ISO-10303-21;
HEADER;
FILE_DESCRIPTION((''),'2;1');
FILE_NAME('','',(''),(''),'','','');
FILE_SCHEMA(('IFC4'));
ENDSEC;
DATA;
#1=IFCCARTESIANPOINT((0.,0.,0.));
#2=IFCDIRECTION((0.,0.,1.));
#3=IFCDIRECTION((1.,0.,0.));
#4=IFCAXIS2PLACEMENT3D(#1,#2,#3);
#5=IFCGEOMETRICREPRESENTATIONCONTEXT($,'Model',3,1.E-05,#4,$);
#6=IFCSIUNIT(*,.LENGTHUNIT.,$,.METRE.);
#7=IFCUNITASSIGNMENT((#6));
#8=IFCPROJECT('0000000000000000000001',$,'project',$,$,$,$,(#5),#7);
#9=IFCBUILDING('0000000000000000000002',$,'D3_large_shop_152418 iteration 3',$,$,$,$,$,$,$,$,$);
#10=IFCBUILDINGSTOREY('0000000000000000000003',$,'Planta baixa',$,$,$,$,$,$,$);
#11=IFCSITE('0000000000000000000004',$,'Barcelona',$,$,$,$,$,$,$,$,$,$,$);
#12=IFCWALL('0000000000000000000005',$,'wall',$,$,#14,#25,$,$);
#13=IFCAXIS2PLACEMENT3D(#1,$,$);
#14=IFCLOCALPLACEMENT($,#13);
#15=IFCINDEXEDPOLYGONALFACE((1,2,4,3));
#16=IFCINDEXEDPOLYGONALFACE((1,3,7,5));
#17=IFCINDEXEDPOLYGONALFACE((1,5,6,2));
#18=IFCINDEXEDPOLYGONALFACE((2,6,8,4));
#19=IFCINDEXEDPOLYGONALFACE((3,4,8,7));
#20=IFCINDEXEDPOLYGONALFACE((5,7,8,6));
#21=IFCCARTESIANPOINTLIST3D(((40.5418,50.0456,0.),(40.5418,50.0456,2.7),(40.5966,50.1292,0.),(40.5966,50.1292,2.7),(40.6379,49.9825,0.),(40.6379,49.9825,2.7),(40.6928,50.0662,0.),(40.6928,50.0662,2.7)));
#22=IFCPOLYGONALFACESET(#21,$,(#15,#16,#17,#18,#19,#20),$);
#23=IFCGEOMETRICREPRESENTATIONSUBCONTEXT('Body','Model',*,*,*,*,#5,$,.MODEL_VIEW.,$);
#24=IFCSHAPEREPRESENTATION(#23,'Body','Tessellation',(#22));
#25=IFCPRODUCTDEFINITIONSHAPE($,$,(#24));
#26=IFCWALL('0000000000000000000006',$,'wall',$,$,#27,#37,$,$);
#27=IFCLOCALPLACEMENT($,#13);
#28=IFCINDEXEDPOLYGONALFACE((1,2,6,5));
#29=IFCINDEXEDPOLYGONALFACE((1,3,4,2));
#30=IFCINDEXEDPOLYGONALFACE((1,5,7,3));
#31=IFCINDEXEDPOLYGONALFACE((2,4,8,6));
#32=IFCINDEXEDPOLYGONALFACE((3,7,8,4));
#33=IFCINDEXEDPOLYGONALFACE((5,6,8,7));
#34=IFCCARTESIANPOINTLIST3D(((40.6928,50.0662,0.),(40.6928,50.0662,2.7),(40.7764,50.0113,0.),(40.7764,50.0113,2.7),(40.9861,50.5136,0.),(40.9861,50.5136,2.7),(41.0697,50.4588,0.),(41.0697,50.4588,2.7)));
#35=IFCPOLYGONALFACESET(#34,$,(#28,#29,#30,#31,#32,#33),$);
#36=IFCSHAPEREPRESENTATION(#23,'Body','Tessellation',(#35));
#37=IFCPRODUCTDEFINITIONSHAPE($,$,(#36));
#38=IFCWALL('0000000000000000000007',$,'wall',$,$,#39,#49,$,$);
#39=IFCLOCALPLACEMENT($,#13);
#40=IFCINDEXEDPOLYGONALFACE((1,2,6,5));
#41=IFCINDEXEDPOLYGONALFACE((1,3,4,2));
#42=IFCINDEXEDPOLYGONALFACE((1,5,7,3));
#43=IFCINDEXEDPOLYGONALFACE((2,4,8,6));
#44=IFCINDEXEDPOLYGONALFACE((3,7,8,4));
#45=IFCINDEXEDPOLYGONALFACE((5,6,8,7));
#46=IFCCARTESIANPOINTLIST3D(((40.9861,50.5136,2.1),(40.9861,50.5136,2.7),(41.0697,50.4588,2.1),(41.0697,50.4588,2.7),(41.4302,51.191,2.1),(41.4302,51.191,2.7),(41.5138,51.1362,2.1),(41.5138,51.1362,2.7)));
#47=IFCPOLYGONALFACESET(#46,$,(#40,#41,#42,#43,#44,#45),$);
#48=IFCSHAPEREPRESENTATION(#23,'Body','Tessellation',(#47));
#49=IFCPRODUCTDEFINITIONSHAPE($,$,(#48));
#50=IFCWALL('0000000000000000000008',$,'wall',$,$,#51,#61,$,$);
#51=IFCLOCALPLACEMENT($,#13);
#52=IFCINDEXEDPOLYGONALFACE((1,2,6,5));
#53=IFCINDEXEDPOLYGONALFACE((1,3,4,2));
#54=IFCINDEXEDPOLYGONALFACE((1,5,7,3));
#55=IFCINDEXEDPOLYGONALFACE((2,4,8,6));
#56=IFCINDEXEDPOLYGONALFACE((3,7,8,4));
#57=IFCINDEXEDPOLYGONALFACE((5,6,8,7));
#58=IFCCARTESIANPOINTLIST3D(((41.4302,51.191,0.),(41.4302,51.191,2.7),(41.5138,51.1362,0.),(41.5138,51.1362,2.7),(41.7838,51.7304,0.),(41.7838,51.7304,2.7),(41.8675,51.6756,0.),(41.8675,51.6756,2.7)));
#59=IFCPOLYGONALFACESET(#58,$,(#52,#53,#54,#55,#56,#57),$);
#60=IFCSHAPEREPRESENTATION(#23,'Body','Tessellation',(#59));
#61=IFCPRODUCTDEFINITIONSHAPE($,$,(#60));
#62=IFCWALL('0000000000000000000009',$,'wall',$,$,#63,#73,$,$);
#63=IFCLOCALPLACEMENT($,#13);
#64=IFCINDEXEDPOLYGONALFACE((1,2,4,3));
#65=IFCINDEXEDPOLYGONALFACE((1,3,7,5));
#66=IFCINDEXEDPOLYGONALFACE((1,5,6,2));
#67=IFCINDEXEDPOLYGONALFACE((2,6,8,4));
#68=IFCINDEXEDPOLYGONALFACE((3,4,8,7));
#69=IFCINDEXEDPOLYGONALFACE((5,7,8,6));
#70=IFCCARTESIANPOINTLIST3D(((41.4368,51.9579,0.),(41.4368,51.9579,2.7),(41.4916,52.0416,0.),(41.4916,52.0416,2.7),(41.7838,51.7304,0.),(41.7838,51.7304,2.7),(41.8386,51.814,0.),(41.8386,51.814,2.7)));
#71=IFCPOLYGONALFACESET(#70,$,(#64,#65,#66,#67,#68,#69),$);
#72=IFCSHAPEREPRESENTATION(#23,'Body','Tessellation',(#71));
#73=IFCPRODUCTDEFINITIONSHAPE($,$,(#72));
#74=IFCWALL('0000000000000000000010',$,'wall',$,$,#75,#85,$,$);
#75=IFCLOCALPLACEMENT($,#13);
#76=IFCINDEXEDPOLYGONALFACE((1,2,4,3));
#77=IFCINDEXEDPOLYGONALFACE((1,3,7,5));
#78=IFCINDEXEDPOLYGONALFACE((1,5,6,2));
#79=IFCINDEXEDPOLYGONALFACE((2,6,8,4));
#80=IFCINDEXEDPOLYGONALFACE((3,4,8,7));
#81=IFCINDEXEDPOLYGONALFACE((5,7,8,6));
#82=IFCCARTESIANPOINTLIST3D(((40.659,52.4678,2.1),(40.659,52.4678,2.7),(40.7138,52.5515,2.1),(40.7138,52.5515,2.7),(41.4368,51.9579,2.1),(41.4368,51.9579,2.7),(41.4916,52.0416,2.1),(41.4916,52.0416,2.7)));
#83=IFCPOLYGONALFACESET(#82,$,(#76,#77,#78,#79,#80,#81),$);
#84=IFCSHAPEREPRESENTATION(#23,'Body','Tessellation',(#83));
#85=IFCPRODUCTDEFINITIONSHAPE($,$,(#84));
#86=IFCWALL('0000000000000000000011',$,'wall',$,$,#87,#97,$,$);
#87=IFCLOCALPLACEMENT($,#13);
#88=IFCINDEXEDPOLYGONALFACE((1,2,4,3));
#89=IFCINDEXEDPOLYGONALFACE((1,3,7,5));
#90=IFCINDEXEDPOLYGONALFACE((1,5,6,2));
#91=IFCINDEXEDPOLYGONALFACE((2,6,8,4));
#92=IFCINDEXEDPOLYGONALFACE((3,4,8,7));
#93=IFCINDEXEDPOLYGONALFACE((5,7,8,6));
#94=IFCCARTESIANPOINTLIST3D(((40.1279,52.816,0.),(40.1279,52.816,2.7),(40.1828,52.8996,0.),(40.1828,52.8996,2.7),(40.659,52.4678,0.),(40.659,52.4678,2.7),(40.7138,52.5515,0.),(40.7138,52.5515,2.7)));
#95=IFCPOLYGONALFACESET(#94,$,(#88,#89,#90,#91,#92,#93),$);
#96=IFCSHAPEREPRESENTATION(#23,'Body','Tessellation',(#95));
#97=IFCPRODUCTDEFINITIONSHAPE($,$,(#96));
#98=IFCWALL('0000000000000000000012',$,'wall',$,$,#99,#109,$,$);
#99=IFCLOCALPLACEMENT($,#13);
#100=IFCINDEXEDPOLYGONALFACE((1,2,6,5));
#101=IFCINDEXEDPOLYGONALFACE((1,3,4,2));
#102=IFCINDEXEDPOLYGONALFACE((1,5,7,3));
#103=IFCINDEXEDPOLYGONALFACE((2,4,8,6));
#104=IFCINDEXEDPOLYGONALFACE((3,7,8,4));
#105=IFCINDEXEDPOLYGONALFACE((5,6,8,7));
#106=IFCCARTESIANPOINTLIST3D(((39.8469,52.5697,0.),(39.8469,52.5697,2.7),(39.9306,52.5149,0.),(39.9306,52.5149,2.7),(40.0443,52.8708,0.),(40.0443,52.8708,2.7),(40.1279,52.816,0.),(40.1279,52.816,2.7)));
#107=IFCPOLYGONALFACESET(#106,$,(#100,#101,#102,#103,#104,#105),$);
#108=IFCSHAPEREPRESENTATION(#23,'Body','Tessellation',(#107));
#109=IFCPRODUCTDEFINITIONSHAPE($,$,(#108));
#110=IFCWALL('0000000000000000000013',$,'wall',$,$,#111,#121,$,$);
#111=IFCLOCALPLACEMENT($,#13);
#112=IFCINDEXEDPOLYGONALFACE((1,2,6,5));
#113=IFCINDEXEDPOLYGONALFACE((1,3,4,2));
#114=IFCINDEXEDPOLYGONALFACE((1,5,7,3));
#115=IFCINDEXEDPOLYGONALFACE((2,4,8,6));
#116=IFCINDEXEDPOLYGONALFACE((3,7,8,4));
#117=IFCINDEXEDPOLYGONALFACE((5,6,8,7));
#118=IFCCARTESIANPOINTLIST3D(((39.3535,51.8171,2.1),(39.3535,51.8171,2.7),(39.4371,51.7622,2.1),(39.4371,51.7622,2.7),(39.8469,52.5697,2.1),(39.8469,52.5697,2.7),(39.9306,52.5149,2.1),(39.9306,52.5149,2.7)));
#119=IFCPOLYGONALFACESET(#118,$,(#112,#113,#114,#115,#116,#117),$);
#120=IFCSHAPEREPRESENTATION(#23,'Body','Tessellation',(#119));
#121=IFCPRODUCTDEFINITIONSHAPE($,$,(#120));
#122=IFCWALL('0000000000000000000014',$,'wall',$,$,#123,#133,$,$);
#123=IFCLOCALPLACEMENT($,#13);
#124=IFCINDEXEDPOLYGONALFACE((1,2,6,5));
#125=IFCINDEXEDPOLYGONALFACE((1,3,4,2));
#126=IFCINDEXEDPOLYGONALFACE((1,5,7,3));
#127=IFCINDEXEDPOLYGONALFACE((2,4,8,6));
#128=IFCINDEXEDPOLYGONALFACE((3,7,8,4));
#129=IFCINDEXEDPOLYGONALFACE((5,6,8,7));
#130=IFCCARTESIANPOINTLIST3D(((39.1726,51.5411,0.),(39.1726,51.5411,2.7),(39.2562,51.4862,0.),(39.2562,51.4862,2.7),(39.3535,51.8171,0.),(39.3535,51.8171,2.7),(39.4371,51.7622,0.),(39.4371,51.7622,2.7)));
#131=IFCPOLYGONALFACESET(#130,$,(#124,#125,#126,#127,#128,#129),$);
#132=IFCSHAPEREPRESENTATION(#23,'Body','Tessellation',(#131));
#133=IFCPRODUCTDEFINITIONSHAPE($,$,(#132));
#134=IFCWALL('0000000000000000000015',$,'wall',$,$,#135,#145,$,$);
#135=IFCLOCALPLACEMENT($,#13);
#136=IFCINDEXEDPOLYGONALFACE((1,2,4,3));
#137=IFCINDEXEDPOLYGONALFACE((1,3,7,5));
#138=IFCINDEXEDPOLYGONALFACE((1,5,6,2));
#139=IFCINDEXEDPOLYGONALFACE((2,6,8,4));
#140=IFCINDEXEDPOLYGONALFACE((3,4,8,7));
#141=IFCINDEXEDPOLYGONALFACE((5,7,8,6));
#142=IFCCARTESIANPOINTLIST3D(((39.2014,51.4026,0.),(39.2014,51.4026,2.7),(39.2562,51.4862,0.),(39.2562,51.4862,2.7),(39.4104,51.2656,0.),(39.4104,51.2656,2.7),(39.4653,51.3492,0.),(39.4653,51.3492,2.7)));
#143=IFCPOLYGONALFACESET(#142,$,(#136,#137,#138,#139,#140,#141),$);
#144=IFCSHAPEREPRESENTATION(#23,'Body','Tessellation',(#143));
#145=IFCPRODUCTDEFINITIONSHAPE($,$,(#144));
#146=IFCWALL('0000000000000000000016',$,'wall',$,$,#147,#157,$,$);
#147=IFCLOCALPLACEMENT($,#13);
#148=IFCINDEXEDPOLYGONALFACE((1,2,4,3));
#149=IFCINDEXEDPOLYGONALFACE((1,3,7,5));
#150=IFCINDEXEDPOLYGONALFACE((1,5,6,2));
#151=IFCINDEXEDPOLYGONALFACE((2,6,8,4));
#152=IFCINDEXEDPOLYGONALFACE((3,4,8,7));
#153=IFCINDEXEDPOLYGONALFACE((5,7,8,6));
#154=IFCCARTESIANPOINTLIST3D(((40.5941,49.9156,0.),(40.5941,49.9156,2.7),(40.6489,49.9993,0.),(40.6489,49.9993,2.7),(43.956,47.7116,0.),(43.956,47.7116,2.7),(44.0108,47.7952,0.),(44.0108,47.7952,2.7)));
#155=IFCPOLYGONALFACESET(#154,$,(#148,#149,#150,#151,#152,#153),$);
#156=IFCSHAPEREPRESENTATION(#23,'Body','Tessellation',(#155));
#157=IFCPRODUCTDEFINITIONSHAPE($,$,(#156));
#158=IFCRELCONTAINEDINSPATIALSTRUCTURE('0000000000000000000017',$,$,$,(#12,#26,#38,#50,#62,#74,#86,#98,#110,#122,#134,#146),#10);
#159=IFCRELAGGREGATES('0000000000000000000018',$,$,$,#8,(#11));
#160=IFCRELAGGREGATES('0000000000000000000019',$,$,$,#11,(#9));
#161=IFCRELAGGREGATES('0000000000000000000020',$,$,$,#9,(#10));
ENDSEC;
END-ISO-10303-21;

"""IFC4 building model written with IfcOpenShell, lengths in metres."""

from ifc_helpers import new_model, si_unit, frame, origin, origin_with_axes, place, context, subcontext, project, spatial, polyline, outline, extrude, element, save


model = new_model("IFC4")

# Units and contexts
model_context = context("Model", 3, precision=1e-05, world=origin_with_axes())
body_context = subcontext(model_context, "Body", "Model", "MODEL_VIEW")
ifc_project = project(units=[si_unit("LENGTHUNIT", "METRE")], contexts=[model_context])

# Site, building, storey
site = spatial("IfcSite", under=ifc_project, Name="Barcelona")
building = spatial("IfcBuilding", under=site, Name="D3_large_shop_152418 iteration 3")
storey = spatial("IfcBuildingStorey", under=building, Name="Planta baixa")

# Walls
wall_1_placement = place(None, origin_with_axes())
element("IfcWall", 1, at=wall_1_placement, inside=storey, Name="wall", context=body_context, shape_type="SweptSolid", body=[
    extrude(outline(polyline([(40.5966, 50.1292), (40.6928, 50.0662), (40.6379, 49.9825), (40.5418, 50.0456), (40.5966, 50.1292)])), origin(), (0.0, 0.0, 1.0), 2.7),
])
wall_2_placement = place(None, origin_with_axes())
element("IfcWall", 2, at=wall_2_placement, inside=storey, Name="wall", context=body_context, shape_type="SweptSolid", body=[
    extrude(outline(polyline([(40.6928, 50.0662), (40.9861, 50.5136), (41.0697, 50.4588), (40.7764, 50.0113), (40.6928, 50.0662)])), origin(), (0.0, 0.0, 1.0), 2.7),
])
wall_3_placement = place(None, origin_with_axes())
element("IfcWall", 3, at=wall_3_placement, inside=storey, Name="wall", context=body_context, shape_type="SweptSolid", body=[
    extrude(outline(polyline([(40.9861, 50.5136), (41.4302, 51.191), (41.5138, 51.1362), (41.0697, 50.4588), (40.9861, 50.5136)])), frame((0.0, 0.0, 2.1)), (0.0, 0.0, 1.0), 0.6),
])
wall_4_placement = place(None, origin_with_axes())
element("IfcWall", 4, at=wall_4_placement, inside=storey, Name="wall", context=body_context, shape_type="SweptSolid", body=[
    extrude(outline(polyline([(41.4302, 51.191), (41.7838, 51.7304), (41.8675, 51.6756), (41.5138, 51.1362), (41.4302, 51.191)])), origin(), (0.0, 0.0, 1.0), 2.7),
])
wall_5_placement = place(None, origin_with_axes())
element("IfcWall", 5, at=wall_5_placement, inside=storey, Name="wall", context=body_context, shape_type="SweptSolid", body=[
    extrude(outline(polyline([(41.7838, 51.7304), (41.4368, 51.9579), (41.4916, 52.0416), (41.8386, 51.814), (41.7838, 51.7304)])), origin(), (0.0, 0.0, 1.0), 2.7),
])
wall_6_placement = place(None, origin_with_axes())
element("IfcWall", 6, at=wall_6_placement, inside=storey, Name="wall", context=body_context, shape_type="SweptSolid", body=[
    extrude(outline(polyline([(41.4368, 51.9579), (40.659, 52.4678), (40.7138, 52.5515), (41.4916, 52.0416), (41.4368, 51.9579)])), frame((0.0, 0.0, 2.1)), (0.0, 0.0, 1.0), 0.6),
])
wall_7_placement = place(None, origin_with_axes())
element("IfcWall", 7, at=wall_7_placement, inside=storey, Name="wall", context=body_context, shape_type="SweptSolid", body=[
    extrude(outline(polyline([(40.659, 52.4678), (40.1279, 52.816), (40.1828, 52.8996), (40.7138, 52.5515), (40.659, 52.4678)])), origin(), (0.0, 0.0, 1.0), 2.7),
])
wall_8_placement = place(None, origin_with_axes())
element("IfcWall", 8, at=wall_8_placement, inside=storey, Name="wall", context=body_context, shape_type="SweptSolid", body=[
    extrude(outline(polyline([(40.1279, 52.816), (39.9306, 52.5149), (39.8469, 52.5697), (40.0443, 52.8708), (40.1279, 52.816)])), origin(), (0.0, 0.0, 1.0), 2.7),
])
wall_9_placement = place(None, origin_with_axes())
element("IfcWall", 9, at=wall_9_placement, inside=storey, Name="wall", context=body_context, shape_type="SweptSolid", body=[
    extrude(outline(polyline([(39.9306, 52.5149), (39.4371, 51.7622), (39.3535, 51.8171), (39.8469, 52.5697), (39.9306, 52.5149)])), frame((0.0, 0.0, 2.1)), (0.0, 0.0, 1.0), 0.6),
])
wall_10_placement = place(None, origin_with_axes())
element("IfcWall", 10, at=wall_10_placement, inside=storey, Name="wall", context=body_context, shape_type="SweptSolid", body=[
    extrude(outline(polyline([(39.4371, 51.7622), (39.2562, 51.4862), (39.1726, 51.5411), (39.3535, 51.8171), (39.4371, 51.7622)])), origin(), (0.0, 0.0, 1.0), 2.7),
])
wall_11_placement = place(None, origin_with_axes())
element("IfcWall", 11, at=wall_11_placement, inside=storey, Name="wall", context=body_context, shape_type="SweptSolid", body=[
    extrude(outline(polyline([(39.2562, 51.4862), (39.4653, 51.3492), (39.4104, 51.2656), (39.2014, 51.4026), (39.2562, 51.4862)])), origin(), (0.0, 0.0, 1.0), 2.7),
])
wall_12_placement = place(None, origin_with_axes())
element("IfcWall", 12, at=wall_12_placement, inside=storey, Name="wall", context=body_context, shape_type="SweptSolid", body=[
    extrude(outline(polyline([(43.956, 47.7116), (40.5941, 49.9156), (40.6489, 49.9993), (44.0108, 47.7952), (43.956, 47.7116)])), origin(), (0.0, 0.0, 1.0), 2.7),
])

save(model, "model.ifc")
